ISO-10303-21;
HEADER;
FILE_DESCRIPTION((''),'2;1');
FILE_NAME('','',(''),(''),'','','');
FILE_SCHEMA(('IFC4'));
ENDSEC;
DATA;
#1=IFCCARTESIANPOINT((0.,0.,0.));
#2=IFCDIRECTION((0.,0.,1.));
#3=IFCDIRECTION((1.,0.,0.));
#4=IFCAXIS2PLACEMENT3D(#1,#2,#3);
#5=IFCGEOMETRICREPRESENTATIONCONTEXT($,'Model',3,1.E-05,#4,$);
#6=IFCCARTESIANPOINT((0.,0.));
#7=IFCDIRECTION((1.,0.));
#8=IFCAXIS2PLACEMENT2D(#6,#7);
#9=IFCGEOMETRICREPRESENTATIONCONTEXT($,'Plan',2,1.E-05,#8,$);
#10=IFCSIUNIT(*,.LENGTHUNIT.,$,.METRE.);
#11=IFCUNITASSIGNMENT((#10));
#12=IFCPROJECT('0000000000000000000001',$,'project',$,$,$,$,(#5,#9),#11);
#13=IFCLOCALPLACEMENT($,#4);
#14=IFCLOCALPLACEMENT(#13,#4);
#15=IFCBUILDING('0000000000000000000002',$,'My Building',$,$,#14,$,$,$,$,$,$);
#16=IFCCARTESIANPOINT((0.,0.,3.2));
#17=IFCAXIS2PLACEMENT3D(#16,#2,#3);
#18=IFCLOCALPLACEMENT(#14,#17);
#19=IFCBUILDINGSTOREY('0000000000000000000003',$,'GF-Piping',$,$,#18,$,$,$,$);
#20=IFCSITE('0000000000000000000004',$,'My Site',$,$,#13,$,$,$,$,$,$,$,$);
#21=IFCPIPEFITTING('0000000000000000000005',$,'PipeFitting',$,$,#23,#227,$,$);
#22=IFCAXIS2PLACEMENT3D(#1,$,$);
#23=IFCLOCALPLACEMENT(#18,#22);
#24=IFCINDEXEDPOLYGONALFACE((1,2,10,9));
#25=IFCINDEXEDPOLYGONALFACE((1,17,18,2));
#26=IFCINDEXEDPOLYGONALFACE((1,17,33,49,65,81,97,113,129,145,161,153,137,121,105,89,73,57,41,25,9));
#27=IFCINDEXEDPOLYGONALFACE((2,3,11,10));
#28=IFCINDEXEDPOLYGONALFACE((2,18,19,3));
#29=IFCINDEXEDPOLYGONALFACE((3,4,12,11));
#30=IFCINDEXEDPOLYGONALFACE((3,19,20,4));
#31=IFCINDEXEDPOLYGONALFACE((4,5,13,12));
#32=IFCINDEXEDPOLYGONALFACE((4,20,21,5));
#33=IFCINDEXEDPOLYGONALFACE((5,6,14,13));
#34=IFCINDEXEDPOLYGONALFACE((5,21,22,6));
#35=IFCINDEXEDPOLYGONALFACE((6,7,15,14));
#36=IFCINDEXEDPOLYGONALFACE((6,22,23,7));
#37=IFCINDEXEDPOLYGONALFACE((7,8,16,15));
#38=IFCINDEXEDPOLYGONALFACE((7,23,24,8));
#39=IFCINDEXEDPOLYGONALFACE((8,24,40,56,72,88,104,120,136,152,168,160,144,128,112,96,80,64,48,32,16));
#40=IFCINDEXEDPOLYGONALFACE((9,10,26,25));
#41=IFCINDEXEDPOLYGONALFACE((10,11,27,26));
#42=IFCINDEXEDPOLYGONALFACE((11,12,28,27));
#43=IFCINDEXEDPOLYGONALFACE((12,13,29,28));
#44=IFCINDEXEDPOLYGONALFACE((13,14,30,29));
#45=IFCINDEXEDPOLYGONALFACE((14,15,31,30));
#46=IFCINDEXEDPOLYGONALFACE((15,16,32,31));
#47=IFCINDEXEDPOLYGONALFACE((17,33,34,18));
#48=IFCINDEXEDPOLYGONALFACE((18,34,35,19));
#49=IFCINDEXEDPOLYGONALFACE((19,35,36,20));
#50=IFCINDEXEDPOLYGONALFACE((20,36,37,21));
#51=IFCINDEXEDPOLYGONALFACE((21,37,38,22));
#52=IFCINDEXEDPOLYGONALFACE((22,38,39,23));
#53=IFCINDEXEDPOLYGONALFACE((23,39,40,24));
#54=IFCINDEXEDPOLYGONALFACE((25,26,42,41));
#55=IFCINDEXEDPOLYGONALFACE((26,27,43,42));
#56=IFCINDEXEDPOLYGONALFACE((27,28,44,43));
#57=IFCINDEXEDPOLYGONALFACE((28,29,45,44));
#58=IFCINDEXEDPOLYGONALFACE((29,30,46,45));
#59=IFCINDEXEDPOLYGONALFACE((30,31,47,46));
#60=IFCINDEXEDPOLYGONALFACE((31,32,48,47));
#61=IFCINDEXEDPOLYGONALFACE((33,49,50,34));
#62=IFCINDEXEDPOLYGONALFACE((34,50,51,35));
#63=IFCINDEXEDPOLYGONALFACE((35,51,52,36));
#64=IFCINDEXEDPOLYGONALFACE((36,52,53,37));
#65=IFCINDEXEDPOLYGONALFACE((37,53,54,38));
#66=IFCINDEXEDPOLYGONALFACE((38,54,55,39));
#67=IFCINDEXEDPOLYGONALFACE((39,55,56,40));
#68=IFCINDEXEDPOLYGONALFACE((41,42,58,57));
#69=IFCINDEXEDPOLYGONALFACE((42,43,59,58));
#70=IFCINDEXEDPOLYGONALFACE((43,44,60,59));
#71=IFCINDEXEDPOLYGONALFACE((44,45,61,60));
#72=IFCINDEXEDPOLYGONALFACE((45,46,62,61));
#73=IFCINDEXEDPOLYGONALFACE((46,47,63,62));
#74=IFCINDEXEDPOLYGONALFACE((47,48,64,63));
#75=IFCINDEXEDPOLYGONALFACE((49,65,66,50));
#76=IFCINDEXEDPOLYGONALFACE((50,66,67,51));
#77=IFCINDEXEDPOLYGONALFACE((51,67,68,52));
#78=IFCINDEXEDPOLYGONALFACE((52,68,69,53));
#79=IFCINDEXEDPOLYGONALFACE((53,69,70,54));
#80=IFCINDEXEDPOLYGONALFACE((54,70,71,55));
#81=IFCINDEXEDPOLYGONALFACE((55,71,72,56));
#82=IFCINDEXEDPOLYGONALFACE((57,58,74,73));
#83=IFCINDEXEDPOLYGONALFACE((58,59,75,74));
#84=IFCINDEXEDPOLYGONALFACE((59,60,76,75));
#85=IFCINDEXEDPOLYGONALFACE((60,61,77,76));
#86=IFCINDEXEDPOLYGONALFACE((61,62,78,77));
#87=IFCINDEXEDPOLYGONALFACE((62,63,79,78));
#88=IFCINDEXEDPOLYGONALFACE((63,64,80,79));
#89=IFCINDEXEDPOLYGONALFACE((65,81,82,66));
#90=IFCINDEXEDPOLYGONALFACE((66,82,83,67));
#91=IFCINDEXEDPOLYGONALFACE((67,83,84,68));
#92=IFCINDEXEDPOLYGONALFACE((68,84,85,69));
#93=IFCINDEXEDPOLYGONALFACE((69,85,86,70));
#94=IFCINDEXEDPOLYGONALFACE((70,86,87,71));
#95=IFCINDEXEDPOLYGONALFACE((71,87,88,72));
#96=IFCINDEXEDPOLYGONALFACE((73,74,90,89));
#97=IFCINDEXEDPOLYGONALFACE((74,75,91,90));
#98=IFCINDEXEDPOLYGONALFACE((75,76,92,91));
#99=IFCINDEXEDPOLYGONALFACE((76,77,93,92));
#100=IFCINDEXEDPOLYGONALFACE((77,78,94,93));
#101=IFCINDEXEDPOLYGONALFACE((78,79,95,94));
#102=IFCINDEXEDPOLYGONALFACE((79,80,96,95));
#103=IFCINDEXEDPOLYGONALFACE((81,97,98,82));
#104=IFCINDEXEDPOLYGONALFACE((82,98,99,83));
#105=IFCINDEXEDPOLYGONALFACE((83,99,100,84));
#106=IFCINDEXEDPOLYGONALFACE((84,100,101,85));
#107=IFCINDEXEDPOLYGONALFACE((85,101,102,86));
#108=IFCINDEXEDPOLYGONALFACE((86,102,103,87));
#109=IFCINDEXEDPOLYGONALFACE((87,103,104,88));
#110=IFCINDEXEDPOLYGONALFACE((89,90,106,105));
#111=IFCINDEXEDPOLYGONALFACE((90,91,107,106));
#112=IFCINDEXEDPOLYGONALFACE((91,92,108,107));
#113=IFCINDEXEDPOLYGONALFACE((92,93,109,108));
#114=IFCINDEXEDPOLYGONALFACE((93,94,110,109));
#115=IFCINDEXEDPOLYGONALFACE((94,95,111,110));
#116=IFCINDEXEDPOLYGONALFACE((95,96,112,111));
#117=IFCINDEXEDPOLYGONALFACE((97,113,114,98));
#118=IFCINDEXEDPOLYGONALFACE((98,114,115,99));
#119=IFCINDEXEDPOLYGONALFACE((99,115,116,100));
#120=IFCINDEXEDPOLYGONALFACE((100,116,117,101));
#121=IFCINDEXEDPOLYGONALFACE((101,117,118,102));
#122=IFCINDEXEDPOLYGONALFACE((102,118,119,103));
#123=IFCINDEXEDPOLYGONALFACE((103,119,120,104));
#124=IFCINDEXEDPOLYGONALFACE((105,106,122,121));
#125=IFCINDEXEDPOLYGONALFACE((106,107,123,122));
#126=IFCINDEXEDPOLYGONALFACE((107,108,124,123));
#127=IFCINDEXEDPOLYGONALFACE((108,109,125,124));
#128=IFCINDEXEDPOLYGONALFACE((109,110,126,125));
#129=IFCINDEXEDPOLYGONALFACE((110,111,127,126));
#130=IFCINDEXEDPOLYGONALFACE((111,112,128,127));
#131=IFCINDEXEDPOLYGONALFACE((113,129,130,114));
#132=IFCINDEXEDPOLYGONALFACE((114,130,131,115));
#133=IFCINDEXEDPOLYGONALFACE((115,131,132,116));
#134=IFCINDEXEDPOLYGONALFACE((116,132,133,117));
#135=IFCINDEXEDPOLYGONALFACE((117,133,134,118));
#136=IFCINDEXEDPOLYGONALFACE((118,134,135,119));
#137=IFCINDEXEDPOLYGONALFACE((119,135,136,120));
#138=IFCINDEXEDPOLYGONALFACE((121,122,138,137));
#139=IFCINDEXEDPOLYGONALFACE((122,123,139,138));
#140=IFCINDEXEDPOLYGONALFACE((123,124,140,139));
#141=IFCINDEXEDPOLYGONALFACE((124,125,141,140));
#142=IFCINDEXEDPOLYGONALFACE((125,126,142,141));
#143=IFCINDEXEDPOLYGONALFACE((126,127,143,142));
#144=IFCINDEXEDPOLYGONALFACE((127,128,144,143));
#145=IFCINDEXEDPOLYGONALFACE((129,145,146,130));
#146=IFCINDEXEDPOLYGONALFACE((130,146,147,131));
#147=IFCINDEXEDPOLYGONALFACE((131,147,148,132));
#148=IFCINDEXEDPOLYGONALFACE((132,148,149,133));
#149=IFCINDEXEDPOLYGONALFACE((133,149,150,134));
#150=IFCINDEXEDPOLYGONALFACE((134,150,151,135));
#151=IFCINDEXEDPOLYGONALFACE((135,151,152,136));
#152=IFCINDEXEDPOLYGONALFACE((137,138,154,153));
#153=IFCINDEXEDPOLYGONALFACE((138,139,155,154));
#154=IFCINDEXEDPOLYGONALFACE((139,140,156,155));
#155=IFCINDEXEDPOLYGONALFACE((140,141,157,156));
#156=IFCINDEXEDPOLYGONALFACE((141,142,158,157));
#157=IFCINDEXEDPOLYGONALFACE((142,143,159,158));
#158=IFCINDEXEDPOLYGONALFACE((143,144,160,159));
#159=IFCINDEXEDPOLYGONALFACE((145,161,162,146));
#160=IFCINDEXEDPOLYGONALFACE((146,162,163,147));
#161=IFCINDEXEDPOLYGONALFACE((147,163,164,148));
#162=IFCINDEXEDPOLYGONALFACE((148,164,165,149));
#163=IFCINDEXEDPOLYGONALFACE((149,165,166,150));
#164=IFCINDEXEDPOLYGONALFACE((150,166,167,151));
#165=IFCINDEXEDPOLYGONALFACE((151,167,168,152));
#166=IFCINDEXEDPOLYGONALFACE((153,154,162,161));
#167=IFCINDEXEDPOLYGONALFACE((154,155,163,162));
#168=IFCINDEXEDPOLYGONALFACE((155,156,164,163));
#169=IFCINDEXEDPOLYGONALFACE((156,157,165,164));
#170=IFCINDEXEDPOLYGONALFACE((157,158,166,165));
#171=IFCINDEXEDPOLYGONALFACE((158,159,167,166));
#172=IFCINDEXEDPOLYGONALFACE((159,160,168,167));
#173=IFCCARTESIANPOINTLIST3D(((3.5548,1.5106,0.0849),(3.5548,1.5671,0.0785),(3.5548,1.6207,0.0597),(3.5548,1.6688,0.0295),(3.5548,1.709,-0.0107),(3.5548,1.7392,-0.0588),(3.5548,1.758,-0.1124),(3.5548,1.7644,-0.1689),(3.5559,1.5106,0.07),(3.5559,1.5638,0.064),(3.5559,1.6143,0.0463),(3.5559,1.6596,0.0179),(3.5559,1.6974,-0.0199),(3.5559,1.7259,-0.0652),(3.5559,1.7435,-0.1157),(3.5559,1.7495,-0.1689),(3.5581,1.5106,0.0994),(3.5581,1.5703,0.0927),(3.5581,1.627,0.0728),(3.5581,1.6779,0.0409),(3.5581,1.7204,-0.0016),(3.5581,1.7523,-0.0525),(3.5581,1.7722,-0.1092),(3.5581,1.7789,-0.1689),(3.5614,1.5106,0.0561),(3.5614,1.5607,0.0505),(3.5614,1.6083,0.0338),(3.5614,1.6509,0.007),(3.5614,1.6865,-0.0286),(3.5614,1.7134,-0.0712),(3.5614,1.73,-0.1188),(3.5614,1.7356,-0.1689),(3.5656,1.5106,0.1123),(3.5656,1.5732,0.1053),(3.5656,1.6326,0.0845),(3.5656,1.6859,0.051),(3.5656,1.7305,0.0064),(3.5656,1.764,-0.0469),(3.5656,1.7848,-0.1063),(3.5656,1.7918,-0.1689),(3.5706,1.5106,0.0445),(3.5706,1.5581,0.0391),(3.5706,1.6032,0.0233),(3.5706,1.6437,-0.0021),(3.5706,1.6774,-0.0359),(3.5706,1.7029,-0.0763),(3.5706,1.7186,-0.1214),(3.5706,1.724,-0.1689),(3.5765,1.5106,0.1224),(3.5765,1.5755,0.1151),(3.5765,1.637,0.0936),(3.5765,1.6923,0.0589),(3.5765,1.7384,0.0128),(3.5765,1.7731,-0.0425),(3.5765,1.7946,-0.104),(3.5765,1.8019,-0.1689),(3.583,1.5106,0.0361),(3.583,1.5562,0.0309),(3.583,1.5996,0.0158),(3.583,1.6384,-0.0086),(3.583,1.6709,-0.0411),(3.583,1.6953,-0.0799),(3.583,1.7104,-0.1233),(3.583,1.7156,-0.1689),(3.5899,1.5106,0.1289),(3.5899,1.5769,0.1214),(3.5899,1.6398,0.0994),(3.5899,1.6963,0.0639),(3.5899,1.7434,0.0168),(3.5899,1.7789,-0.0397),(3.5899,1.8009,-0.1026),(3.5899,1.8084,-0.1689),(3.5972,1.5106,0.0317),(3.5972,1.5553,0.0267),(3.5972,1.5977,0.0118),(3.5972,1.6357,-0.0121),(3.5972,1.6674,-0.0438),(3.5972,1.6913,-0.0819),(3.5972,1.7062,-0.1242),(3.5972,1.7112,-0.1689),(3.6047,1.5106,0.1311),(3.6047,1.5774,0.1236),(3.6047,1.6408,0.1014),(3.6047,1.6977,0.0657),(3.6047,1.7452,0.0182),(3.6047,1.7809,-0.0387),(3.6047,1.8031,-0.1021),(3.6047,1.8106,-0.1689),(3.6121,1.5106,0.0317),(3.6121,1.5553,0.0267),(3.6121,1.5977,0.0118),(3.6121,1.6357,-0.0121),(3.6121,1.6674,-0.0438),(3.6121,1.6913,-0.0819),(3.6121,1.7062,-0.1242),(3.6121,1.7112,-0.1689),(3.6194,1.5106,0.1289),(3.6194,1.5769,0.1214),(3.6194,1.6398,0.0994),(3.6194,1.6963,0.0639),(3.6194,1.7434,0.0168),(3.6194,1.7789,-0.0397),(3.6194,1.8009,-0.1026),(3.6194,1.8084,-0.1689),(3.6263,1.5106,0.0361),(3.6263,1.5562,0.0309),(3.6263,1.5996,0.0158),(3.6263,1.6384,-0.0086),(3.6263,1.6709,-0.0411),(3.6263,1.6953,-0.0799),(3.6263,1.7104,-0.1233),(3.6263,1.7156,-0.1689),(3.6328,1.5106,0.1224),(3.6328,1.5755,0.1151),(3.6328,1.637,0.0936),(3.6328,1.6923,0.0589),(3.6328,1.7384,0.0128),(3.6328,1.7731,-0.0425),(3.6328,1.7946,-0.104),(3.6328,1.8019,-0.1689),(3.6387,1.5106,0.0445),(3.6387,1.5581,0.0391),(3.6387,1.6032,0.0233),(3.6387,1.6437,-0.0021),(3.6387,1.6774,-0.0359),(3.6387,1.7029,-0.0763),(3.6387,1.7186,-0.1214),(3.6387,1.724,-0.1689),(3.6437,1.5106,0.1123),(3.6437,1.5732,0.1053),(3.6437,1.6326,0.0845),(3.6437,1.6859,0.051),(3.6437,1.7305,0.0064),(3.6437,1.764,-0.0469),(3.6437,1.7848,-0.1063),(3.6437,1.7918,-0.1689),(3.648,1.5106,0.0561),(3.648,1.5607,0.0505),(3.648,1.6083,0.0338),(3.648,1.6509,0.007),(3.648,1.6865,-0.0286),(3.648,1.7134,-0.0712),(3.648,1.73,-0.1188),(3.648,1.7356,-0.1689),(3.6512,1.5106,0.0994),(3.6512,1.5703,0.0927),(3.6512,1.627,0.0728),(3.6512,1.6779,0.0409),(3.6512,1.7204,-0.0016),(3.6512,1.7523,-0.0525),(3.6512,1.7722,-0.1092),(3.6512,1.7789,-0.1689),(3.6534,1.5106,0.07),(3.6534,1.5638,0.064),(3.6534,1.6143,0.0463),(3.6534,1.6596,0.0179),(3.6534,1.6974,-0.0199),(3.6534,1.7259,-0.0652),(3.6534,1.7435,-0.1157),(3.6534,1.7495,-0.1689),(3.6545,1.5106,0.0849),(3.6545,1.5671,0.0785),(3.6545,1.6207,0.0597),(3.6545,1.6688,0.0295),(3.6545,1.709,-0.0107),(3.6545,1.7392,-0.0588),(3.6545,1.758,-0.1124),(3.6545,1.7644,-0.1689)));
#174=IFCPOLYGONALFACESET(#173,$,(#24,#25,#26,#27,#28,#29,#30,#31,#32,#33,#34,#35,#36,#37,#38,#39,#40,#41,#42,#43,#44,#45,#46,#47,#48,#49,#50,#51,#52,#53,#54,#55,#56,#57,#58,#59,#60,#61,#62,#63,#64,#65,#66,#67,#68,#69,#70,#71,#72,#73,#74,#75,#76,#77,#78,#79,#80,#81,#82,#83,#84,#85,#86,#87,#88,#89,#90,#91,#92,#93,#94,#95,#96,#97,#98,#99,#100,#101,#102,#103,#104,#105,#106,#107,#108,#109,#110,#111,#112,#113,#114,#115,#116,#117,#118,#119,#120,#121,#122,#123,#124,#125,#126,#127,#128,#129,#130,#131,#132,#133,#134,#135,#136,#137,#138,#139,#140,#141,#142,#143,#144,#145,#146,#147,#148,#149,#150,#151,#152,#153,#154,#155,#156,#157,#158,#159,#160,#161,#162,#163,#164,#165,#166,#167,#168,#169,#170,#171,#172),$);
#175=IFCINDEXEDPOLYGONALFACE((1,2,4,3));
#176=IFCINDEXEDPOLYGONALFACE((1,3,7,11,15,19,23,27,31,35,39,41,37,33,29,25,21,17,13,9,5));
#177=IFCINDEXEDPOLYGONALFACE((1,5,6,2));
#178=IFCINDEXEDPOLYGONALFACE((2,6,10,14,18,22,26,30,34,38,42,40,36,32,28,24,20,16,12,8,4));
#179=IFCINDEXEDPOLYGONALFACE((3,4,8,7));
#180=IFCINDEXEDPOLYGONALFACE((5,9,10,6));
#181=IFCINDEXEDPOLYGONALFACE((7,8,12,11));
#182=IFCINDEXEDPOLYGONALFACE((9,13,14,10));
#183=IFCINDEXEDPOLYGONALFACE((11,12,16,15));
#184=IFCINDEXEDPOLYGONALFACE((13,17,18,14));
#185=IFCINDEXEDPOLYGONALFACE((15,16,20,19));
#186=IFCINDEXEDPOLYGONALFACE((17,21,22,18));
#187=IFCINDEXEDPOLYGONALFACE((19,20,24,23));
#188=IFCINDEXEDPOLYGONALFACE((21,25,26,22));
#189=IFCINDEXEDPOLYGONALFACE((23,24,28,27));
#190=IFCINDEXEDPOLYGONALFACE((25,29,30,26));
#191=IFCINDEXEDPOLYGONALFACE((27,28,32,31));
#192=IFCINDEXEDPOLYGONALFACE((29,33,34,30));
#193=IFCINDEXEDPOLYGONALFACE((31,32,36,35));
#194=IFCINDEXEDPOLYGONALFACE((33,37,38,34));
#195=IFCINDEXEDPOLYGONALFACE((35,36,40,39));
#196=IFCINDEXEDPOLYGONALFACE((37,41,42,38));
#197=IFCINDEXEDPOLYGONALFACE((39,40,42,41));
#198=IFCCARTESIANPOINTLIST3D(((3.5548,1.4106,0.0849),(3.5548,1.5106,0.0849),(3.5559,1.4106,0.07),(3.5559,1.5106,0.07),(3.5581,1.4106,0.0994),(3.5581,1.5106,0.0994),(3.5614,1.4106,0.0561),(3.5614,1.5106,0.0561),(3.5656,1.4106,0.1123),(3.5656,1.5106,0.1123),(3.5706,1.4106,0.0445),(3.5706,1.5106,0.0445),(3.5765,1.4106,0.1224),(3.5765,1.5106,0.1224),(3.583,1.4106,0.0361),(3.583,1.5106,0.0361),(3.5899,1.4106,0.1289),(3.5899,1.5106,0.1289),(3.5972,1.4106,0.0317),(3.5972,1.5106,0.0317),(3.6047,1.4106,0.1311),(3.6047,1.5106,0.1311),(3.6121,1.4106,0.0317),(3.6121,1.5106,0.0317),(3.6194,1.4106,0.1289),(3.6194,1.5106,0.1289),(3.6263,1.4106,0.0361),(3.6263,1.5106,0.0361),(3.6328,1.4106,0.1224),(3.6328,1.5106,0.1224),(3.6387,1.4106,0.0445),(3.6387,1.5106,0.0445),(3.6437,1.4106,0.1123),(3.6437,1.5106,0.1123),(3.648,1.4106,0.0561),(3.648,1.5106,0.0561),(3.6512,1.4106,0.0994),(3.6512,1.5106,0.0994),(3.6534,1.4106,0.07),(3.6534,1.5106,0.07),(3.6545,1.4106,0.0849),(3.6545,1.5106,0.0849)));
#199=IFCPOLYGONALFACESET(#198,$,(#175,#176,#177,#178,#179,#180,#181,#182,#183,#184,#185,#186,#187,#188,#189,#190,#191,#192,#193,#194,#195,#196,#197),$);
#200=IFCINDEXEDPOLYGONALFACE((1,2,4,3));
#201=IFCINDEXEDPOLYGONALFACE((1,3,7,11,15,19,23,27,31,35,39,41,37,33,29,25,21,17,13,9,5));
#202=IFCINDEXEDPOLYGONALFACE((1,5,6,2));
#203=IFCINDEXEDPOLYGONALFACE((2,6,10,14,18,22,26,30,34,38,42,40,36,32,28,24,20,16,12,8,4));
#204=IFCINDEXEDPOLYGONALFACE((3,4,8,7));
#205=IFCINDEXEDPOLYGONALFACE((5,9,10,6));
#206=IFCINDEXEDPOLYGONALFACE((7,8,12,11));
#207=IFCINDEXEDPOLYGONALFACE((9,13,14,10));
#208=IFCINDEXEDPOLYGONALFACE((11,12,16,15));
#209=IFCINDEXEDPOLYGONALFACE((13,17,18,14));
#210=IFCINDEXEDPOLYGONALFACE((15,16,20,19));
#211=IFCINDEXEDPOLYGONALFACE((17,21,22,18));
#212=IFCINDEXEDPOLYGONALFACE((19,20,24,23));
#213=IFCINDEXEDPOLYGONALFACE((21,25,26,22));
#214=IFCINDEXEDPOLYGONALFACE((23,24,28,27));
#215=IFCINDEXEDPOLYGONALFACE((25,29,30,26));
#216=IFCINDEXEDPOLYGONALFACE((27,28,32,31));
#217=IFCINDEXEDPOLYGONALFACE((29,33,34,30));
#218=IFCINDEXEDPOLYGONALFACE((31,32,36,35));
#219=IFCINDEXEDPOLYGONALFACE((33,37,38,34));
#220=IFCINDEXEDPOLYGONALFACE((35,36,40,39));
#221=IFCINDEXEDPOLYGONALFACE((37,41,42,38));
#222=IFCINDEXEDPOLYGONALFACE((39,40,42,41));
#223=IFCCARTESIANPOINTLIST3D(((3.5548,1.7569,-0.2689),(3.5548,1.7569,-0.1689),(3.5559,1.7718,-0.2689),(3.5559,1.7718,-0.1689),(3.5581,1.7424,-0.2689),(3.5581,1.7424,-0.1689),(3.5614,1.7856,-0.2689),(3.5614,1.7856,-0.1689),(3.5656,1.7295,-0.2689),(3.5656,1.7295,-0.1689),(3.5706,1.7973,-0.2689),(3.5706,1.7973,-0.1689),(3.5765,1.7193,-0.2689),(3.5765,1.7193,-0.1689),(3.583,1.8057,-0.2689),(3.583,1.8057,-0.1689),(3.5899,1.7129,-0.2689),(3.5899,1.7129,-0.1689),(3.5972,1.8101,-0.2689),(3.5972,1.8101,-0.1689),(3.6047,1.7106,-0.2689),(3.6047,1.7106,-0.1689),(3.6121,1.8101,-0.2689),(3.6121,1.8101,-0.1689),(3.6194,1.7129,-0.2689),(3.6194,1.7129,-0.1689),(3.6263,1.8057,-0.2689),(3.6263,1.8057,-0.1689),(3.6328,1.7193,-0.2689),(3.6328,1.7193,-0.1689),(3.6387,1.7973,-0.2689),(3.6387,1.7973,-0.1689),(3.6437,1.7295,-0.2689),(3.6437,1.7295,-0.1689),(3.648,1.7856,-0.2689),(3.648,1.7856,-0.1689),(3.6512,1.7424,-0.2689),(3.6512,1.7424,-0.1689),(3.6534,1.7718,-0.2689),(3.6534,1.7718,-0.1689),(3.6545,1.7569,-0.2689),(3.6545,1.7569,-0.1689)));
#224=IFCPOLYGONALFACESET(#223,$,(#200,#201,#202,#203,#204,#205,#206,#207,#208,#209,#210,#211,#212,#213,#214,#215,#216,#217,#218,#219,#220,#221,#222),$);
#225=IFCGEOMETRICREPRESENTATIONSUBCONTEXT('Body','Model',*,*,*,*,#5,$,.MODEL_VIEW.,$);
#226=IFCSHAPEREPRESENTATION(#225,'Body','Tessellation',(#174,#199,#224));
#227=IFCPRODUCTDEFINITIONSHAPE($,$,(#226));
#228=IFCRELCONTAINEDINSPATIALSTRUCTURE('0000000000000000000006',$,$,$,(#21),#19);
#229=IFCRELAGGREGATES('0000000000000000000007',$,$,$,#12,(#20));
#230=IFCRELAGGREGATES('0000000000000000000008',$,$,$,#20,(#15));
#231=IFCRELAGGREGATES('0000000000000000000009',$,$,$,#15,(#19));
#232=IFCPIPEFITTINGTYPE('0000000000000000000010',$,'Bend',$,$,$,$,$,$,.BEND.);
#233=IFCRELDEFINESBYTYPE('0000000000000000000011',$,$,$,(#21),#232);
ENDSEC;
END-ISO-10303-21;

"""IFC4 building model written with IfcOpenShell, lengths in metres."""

from ifc_helpers import new_model, entity, si_unit, frame, origin_with_axes, origin_2d_with_axis, place, context, subcontext, project, spatial, circle, extrude, source, transform, mapped, type_object, type_shapes, element, save


model = new_model("IFC4")

# Units and contexts
model_context = context("Model", 3, precision=1e-05, world=origin_with_axes())
plan_context = context("Plan", 2, precision=1e-05, world=origin_2d_with_axis())
body_context = subcontext(model_context, "Body", "Model", "MODEL_VIEW")
ifc_project = project(units=[si_unit("LENGTHUNIT", "METRE")], contexts=[model_context, plan_context])

# Site, building, storey
site_placement = place(None, origin_with_axes())
site = spatial("IfcSite", under=ifc_project, at=site_placement, Name="My Site")
building_placement = place(site_placement, origin_with_axes())
building = spatial("IfcBuilding", under=site, at=building_placement, Name="My Building")
storey_placement = place(building_placement, frame((0.0, 0.0, 3.2), z_axis=(0.0, 0.0, 1.0), x_axis=(1.0, 0.0, 0.0)))
storey = spatial("IfcBuildingStorey", under=building, at=storey_placement, Name="GF-Piping")

# Pipe fitting
pipe_fitting_type = type_object("IfcPipeFittingType", Name="Bend", PredefinedType="BEND")
shared_shape = source(origin_with_axes(), body_context, "Body", "SolidModel", [
    entity("IfcSweptDiskSolid", entity("IfcIndexedPolyCurve", entity("IfcCartesianPointList3D", [[0.0, 0.0, 0.1], [-0.0732, 0.0, 0.2768], [-0.25, 0.0, 0.35]]), [entity("IfcArcIndex", [1, 2, 3])]), 0.05),
    extrude(circle(Radius=0.05), origin_with_axes(), (0.0, 0.0, 1.0), 0.1),
    extrude(circle(Radius=0.05), frame((-0.25, 0.0, 0.35), z_axis=(-1.0, 0.0, 0.0), x_axis=(0.0, 0.0, -1.0)), (0.0, 0.0, 1.0), 0.1),
])
type_shapes(pipe_fitting_type, [shared_shape])
for number, where, z_axis, x_axis, name in (
    (1, (3.6047, 1.4106, 0.0811), (0.0, 1.0, 0.0), (0.0, 0.0, 1.0), "PipeFitting"),
):
    element("IfcPipeFitting", number, at=place(storey_placement, frame(where, z_axis=z_axis, x_axis=x_axis)), inside=storey, type_object=pipe_fitting_type, Name=name, context=body_context, shape_type="MappedRepresentation", body=[
        mapped(shared_shape, transform((0.0, 0.0, 0.0), x_axis=(1.0, 0.0, 0.0), y_axis=(0.0, 1.0, 0.0), z_axis=(0.0, 0.0, 1.0), scale=1.0)),
    ])

save(model, "model.ifc")
